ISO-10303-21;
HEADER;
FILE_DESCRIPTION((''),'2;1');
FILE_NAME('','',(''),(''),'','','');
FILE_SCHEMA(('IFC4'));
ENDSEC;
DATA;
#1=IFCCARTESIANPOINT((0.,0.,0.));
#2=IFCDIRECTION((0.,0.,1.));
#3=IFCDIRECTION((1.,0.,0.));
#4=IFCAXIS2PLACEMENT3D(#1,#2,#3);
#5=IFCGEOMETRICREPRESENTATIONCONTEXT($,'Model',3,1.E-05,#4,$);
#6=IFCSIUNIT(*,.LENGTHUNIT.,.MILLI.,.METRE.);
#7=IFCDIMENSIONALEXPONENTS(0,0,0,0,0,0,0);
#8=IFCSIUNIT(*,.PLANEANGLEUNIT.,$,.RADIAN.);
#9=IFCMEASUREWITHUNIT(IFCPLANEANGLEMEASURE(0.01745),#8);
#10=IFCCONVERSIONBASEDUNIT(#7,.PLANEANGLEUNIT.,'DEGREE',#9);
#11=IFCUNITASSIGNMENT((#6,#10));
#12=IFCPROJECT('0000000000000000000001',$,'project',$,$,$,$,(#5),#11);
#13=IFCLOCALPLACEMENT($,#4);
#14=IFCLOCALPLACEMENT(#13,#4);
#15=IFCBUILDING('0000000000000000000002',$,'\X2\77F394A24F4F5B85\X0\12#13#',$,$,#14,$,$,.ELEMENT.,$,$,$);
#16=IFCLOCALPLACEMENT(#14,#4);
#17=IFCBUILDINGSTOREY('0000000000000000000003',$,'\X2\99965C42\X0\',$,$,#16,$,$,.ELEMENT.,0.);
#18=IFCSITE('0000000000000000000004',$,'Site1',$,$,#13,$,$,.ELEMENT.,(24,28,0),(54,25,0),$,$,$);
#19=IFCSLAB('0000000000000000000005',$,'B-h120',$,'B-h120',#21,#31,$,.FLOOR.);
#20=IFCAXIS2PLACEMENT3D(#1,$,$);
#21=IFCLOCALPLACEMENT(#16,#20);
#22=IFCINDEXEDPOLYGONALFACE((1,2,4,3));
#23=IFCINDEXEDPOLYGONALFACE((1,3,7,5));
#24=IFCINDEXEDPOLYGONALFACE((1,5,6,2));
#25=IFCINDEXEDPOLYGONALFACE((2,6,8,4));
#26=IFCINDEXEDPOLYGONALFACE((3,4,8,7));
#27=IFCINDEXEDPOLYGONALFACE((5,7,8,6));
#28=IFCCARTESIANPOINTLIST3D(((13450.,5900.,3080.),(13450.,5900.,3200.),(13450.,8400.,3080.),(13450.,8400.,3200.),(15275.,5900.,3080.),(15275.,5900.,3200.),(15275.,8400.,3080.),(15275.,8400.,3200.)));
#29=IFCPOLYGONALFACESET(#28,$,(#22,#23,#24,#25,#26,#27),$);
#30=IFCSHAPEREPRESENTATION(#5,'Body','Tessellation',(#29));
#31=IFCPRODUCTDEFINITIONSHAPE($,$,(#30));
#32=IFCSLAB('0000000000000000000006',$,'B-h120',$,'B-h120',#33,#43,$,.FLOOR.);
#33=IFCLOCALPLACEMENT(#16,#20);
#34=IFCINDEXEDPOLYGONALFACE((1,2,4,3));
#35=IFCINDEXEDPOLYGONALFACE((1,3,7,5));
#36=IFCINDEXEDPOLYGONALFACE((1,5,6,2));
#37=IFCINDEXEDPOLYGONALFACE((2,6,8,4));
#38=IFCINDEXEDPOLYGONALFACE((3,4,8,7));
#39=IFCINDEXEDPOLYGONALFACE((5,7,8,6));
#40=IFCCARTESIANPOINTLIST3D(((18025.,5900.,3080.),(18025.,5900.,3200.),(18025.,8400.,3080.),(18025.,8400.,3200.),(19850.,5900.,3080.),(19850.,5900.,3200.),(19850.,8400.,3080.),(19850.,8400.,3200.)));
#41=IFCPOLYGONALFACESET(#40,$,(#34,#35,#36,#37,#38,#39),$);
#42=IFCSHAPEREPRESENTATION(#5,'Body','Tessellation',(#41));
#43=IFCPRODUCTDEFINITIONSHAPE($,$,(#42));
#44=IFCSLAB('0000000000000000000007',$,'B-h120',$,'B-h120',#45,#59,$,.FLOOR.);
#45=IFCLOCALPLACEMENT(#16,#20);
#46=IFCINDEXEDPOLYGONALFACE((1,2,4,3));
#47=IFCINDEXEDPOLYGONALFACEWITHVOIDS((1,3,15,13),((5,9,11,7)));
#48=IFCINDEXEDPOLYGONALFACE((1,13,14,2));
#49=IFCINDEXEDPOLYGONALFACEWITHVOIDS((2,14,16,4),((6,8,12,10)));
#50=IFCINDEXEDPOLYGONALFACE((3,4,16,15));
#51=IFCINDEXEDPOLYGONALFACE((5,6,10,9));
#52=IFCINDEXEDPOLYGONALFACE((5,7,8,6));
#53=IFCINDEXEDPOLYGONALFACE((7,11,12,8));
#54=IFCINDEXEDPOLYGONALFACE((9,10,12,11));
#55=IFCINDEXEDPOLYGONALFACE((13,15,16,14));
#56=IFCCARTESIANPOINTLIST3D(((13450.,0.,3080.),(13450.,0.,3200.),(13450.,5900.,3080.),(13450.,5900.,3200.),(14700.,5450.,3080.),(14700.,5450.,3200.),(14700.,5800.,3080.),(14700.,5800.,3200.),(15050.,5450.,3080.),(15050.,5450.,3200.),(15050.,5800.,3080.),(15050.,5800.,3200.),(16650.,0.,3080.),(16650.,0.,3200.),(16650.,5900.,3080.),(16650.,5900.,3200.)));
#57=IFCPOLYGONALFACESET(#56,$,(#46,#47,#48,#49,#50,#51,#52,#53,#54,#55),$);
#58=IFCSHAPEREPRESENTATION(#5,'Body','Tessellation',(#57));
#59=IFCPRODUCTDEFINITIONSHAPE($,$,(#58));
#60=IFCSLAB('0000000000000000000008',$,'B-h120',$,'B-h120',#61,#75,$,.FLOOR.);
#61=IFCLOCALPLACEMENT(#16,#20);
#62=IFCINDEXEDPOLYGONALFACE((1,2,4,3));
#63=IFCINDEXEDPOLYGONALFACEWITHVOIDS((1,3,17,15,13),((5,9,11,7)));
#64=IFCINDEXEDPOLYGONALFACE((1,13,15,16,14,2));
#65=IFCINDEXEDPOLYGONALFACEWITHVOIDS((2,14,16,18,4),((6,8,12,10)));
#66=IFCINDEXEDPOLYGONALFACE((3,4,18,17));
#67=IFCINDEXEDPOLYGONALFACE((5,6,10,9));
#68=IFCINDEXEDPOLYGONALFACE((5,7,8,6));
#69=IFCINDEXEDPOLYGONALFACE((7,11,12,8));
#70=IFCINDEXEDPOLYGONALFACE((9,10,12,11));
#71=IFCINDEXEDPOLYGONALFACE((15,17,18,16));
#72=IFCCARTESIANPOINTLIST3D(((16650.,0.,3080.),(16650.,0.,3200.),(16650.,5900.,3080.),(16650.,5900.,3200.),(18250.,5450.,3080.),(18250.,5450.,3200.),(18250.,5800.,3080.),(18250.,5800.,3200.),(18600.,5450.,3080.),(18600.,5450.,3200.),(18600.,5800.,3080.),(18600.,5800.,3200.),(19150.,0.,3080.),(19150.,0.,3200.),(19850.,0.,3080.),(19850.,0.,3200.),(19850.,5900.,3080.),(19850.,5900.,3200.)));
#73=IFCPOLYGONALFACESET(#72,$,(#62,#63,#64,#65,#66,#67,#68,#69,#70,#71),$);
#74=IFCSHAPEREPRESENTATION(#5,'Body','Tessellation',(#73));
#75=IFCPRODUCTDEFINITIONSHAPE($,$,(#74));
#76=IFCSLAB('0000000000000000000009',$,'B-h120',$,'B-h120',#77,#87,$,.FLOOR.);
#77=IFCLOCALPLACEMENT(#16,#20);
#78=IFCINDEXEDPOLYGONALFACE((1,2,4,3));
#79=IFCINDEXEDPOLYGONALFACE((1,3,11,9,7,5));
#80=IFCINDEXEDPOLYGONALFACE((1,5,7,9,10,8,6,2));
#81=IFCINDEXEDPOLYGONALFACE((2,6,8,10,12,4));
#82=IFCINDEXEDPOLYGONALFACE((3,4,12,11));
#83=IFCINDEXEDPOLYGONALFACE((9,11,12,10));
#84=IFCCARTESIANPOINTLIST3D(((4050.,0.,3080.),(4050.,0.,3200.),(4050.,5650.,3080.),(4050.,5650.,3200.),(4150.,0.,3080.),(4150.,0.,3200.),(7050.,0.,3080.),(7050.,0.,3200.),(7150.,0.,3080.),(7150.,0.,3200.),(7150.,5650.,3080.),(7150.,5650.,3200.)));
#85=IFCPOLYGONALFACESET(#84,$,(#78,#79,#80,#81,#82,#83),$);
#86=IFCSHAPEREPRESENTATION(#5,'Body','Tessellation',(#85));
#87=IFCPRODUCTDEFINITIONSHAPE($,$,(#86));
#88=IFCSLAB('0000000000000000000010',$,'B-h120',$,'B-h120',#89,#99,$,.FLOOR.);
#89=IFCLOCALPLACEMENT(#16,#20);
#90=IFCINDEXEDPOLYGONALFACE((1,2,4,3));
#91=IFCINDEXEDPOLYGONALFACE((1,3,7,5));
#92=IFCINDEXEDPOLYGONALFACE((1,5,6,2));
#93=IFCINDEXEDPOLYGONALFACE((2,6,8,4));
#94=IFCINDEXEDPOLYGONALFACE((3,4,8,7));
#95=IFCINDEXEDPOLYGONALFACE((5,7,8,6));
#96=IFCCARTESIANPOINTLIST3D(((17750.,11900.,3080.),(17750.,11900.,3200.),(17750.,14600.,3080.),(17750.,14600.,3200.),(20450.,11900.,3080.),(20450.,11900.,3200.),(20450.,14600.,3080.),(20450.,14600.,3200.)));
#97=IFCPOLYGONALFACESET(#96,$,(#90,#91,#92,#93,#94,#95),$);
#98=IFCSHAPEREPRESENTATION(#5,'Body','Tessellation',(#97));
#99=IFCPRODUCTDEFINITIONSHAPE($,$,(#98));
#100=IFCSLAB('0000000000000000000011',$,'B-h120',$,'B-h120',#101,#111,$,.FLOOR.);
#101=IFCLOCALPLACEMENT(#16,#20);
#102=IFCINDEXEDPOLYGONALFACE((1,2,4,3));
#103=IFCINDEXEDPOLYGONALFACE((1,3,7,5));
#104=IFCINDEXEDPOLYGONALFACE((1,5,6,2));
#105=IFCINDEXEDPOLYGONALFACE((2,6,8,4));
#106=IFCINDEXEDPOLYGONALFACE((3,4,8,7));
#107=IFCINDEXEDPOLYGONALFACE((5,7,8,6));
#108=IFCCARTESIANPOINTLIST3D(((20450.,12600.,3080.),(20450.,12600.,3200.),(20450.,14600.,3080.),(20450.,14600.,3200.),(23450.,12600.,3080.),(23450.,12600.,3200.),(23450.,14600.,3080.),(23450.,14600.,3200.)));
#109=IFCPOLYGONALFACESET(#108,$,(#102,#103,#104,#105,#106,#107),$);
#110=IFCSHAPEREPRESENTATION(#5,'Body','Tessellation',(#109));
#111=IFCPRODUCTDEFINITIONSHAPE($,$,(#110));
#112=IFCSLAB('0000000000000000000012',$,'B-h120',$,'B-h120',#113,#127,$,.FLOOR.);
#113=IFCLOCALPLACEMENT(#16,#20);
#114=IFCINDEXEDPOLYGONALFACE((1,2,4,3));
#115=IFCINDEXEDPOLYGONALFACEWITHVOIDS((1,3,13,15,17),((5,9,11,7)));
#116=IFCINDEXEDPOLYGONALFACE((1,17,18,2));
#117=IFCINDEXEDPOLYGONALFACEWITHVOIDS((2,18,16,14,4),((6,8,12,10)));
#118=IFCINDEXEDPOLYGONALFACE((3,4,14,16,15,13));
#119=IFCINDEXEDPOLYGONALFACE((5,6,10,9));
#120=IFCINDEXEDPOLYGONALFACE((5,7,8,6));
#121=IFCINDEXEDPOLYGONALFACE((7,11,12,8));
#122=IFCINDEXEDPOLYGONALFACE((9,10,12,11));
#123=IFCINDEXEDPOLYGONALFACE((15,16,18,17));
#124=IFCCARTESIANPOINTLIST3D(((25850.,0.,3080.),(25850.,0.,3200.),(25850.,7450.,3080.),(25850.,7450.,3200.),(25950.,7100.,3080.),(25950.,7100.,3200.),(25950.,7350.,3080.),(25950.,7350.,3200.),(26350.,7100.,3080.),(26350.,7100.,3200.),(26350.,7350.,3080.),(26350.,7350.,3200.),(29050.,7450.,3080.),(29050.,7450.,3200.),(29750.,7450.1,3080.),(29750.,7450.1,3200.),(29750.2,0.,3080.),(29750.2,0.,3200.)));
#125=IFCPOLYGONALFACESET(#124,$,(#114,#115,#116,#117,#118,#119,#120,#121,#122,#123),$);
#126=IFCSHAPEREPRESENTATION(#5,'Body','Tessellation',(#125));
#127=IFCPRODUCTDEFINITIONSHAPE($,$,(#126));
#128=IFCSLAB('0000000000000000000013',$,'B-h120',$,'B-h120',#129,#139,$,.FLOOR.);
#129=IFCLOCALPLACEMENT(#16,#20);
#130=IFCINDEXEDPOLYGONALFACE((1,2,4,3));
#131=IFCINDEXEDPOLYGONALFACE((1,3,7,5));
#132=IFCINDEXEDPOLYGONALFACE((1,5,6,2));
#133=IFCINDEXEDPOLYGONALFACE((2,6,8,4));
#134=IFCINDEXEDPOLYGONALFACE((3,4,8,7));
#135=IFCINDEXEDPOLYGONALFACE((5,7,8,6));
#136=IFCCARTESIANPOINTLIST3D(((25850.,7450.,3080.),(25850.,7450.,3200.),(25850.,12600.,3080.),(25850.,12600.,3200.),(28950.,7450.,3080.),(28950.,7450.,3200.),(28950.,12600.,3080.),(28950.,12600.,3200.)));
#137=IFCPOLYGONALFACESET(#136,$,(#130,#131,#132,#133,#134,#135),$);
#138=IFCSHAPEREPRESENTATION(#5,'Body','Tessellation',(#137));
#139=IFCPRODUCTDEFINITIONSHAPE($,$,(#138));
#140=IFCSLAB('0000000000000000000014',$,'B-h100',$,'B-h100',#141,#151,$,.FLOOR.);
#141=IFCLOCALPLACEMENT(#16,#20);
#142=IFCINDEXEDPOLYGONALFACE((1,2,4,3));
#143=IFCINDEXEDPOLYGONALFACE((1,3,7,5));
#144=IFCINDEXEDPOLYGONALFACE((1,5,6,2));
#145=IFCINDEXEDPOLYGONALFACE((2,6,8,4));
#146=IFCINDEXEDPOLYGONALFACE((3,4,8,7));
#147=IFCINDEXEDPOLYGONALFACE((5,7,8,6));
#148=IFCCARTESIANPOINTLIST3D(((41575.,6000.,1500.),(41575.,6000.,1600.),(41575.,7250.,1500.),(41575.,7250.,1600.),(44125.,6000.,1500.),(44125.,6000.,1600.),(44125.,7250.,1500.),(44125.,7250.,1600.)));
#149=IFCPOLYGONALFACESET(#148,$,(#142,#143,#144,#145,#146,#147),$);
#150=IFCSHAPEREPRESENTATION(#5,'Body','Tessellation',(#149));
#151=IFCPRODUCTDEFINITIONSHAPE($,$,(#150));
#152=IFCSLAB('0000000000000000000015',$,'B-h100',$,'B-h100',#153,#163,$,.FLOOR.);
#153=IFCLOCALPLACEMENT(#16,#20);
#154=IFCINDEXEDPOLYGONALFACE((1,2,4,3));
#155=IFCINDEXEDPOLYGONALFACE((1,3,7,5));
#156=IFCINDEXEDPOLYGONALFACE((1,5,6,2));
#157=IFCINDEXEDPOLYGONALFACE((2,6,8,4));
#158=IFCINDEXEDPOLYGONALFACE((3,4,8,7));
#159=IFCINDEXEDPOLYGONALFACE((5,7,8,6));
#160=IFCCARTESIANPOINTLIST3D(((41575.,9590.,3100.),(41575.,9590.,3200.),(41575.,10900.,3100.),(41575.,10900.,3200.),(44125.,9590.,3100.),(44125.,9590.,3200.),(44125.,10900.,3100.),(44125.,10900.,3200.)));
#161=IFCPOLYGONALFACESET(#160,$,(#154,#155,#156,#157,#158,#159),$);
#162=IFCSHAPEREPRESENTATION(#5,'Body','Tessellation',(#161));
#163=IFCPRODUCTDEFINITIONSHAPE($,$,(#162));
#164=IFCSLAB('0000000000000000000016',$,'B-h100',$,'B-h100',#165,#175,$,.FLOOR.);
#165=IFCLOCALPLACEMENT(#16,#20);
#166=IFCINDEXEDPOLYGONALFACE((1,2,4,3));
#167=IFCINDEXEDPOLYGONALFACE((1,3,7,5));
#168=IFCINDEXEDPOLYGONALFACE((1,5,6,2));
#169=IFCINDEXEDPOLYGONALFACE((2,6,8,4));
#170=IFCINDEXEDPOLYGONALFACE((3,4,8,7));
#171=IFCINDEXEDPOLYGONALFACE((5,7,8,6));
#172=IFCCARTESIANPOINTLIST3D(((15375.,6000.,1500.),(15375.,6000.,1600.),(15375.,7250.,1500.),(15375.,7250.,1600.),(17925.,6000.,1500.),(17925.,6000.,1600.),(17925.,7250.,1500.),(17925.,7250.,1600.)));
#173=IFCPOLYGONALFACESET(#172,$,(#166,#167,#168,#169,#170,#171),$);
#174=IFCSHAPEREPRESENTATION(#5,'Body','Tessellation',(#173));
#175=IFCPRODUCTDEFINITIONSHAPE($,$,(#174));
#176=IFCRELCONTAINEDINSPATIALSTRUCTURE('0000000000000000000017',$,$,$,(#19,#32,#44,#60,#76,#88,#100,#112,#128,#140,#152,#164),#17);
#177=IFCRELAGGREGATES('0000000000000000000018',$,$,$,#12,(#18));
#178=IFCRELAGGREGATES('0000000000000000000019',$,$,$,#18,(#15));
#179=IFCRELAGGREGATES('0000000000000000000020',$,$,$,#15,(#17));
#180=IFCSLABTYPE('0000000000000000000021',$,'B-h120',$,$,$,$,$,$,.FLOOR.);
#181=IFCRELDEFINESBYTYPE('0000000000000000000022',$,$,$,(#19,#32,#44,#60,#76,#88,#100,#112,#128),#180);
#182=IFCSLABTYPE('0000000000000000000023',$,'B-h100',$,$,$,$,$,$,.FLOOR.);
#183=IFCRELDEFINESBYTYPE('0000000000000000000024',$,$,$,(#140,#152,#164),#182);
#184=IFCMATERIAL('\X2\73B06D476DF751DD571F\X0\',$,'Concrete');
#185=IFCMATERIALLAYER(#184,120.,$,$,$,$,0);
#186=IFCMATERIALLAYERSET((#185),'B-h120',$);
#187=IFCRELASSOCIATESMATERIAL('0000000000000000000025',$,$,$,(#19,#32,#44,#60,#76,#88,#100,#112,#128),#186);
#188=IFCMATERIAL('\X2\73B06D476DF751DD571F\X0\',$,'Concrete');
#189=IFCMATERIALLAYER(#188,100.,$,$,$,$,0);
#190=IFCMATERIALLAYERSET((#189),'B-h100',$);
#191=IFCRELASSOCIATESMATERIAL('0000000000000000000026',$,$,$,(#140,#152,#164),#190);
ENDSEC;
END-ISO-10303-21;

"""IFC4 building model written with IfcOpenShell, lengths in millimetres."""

from ifc_helpers import new_model, entity, si_unit, converted_unit, frame, origin_with_axes, place, context, project, spatial, polyline, outline, extrude, material, layer, layer_set, type_object, element, save


model = new_model("IFC4")

# Units and contexts
model_context = context("Model", 3, precision=1e-05, world=origin_with_axes())
ifc_project = project(units=[si_unit("LENGTHUNIT", "METRE", prefix="MILLI"), converted_unit("PLANEANGLEUNIT", "DEGREE", entity("IfcPlaneAngleMeasure", 0.01745), si_unit("PLANEANGLEUNIT", "RADIAN"), dimensions=[0, 0, 0, 0, 0, 0, 0])], contexts=[model_context])

# Site, building, storey
site_placement = place(None, origin_with_axes())
site = spatial("IfcSite", under=ifc_project, at=site_placement, Name="Site1", CompositionType="ELEMENT", RefLatitude=(24, 28, 0), RefLongitude=(54, 25, 0))
building_placement = place(site_placement, origin_with_axes())
building = spatial("IfcBuilding", under=site, at=building_placement, Name="石钢住宅12#13#", CompositionType="ELEMENT")
storey_placement = place(building_placement, origin_with_axes())
storey = spatial("IfcBuildingStorey", under=building, at=storey_placement, Name="首层", CompositionType="ELEMENT", Elevation=0.0)

# Slabs
ifc_material_1 = material(Name="现浇混凝土", Category="Concrete")
ifc_layer_1 = layer(ifc_material_1, 120.0, Priority=0)
ifc_layer_set_1 = layer_set([ifc_layer_1], Name="B-h120")
slab_type_1 = type_object("IfcSlabType", Name="B-h120", PredefinedType="FLOOR")
slab_1_placement = place(storey_placement, origin_with_axes())
element("IfcSlab", 1, at=slab_1_placement, inside=storey, type_object=slab_type_1, material=ifc_layer_set_1, Name="B-h120", ObjectType="B-h120", PredefinedType="FLOOR", context=model_context, shape_type="SweptSolid", body=[
    extrude(outline(polyline([(0.0, 0.0), (2500.0, 0.0), (2500.0, 1825.0), (0.0, 1825.0), (0.0, 0.0)])), frame((13450.0, 5900.0, 3200.0), z_axis=(0.0, 0.0, -1.0), x_axis=(0.0, 1.0, 0.0)), (0.0, 0.0, 1.0), 120.0),
])
slab_2_placement = place(storey_placement, origin_with_axes())
element("IfcSlab", 2, at=slab_2_placement, inside=storey, type_object=slab_type_1, material=ifc_layer_set_1, Name="B-h120", ObjectType="B-h120", PredefinedType="FLOOR", context=model_context, shape_type="SweptSolid", body=[
    extrude(outline(polyline([(0.0, 0.0), (1825.0, 0.0), (1825.0, 2500.0), (0.0, 2500.0), (0.0, 0.0)])), frame((19850.0, 5900.0, 3200.0), z_axis=(0.0, 0.0, -1.0), x_axis=(-1.0, 0.0, 0.0)), (0.0, 0.0, 1.0), 120.0),
])

# Slabs, openings
slab_3_placement = place(storey_placement, origin_with_axes())
slab_3 = element("IfcSlab", 3, at=slab_3_placement, inside=storey, type_object=slab_type_1, material=ifc_layer_set_1, Name="B-h120", ObjectType="B-h120", PredefinedType="FLOOR", context=model_context, shape_type="SweptSolid", body=[
    extrude(outline(polyline([(0.0, 0.0), (3200.0, 0.0), (3200.0, 5900.0), (0.0, 5900.0), (0.0, 0.0)])), frame((16650.0, 0.0, 3200.0), z_axis=(0.0, 0.0, -1.0), x_axis=(-1.0, 0.0, 0.0)), (0.0, 0.0, 1.0), 120.0),
])
opening_1_placement = place(storey_placement, origin_with_axes())
element("IfcOpeningElement", 4, at=opening_1_placement, cuts=slab_3, PredefinedType="OPENING", context=model_context, shape_type="SweptSolid", body=[
    extrude(outline(polyline([(0.0, 0.0), (350.0, 0.0), (350.0, 350.0), (0.0, 350.0), (0.0, 0.0)])), frame((14700.0, 5450.0, -6400.0), z_axis=(0.0, 0.0, 1.0), x_axis=(1.0, 0.0, 0.0)), (0.0, 0.0, 1.0), 19200.0),
])
slab_4_placement = place(storey_placement, origin_with_axes())
slab_4 = element("IfcSlab", 5, at=slab_4_placement, inside=storey, type_object=slab_type_1, material=ifc_layer_set_1, Name="B-h120", ObjectType="B-h120", PredefinedType="FLOOR", context=model_context, shape_type="SweptSolid", body=[
    extrude(outline(polyline([(16650.0, 0.0), (16650.0, -5900.0), (19850.0, -5900.0), (19850.0, 0.0), (19150.0, 0.0), (19150.0, 0.0), (16650.0, 0.0)])), frame((0.0, 0.0, 3200.0), z_axis=(0.0, 0.0, -1.0), x_axis=(1.0, 0.0, 0.0)), (0.0, 0.0, 1.0), 120.0),
])
opening_2_placement = place(storey_placement, origin_with_axes())
element("IfcOpeningElement", 6, at=opening_2_placement, cuts=slab_4, PredefinedType="OPENING", context=model_context, shape_type="SweptSolid", body=[
    extrude(outline(polyline([(0.0, 0.0), (350.0, 0.0), (350.0, 350.0), (0.0, 350.0), (0.0, 0.0)])), frame((18250.0, 5450.0, -6400.0), z_axis=(0.0, 0.0, 1.0), x_axis=(1.0, 0.0, 0.0)), (0.0, 0.0, 1.0), 19200.0),
])

# Slabs
slab_5_placement = place(storey_placement, origin_with_axes())
element("IfcSlab", 7, at=slab_5_placement, inside=storey, type_object=slab_type_1, material=ifc_layer_set_1, Name="B-h120", ObjectType="B-h120", PredefinedType="FLOOR", context=model_context, shape_type="SweptSolid", body=[
    extrude(outline(polyline([(4050.0, -5650.0), (7150.0, -5650.0), (7150.0, 0.0), (7050.0, 0.0), (7050.0, 0.0), (4150.0, 0.0), (4150.0, 0.0), (4050.0, 0.0), (4050.0, -5650.0)])), frame((0.0, 0.0, 3200.0), z_axis=(0.0, 0.0, -1.0), x_axis=(1.0, 0.0, 0.0)), (0.0, 0.0, 1.0), 120.0),
])
slab_6_placement = place(storey_placement, origin_with_axes())
element("IfcSlab", 8, at=slab_6_placement, inside=storey, type_object=slab_type_1, material=ifc_layer_set_1, Name="B-h120", ObjectType="B-h120", PredefinedType="FLOOR", context=model_context, shape_type="SweptSolid", body=[
    extrude(outline(polyline([(0.0, 0.0), (2700.0, 0.0), (2700.0, 2700.0), (0.0, 2700.0), (0.0, 0.0)])), frame((20450.0, 14600.0, 3200.0), z_axis=(0.0, 0.0, -1.0), x_axis=(0.0, -1.0, 0.0)), (0.0, 0.0, 1.0), 120.0),
])
slab_7_placement = place(storey_placement, origin_with_axes())
element("IfcSlab", 9, at=slab_7_placement, inside=storey, type_object=slab_type_1, material=ifc_layer_set_1, Name="B-h120", ObjectType="B-h120", PredefinedType="FLOOR", context=model_context, shape_type="SweptSolid", body=[
    extrude(outline(polyline([(0.0, 0.0), (3000.0, 0.0), (3000.0, 2000.0), (0.0, 2000.0), (0.0, 0.0)])), frame((20450.0, 14600.0, 3200.0), z_axis=(0.0, 0.0, -1.0), x_axis=(1.0, 0.0, 0.0)), (0.0, 0.0, 1.0), 120.0),
])

# Slab, opening
slab_8_placement = place(storey_placement, origin_with_axes())
slab_8 = element("IfcSlab", 10, at=slab_8_placement, inside=storey, type_object=slab_type_1, material=ifc_layer_set_1, Name="B-h120", ObjectType="B-h120", PredefinedType="FLOOR", context=model_context, shape_type="SweptSolid", body=[
    extrude(outline(polyline([(29750.2, 0.0), (25850.0, 0.0), (25850.0, -7450.0), (29050.0, -7450.0), (29050.0, -7450.0), (29750.0, -7450.1), (29750.2, 0.0)])), frame((0.0, 0.0, 3200.0), z_axis=(0.0, 0.0, -1.0), x_axis=(1.0, 0.0, 0.0)), (0.0, 0.0, 1.0), 120.0),
])
opening_3_placement = place(storey_placement, origin_with_axes())
element("IfcOpeningElement", 11, at=opening_3_placement, cuts=slab_8, PredefinedType="OPENING", context=model_context, shape_type="SweptSolid", body=[
    extrude(outline(polyline([(0.0, 0.0), (400.0, 0.0), (400.0, 250.0), (0.0, 250.0), (0.0, 0.0)])), frame((25950.0, 7100.0, -6400.0), z_axis=(0.0, 0.0, 1.0), x_axis=(1.0, 0.0, 0.0)), (0.0, 0.0, 1.0), 19200.0),
])

# Slabs
slab_9_placement = place(storey_placement, origin_with_axes())
element("IfcSlab", 12, at=slab_9_placement, inside=storey, type_object=slab_type_1, material=ifc_layer_set_1, Name="B-h120", ObjectType="B-h120", PredefinedType="FLOOR", context=model_context, shape_type="SweptSolid", body=[
    extrude(outline(polyline([(0.0, 0.0), (5150.0, 0.0), (5150.0, 3100.0), (0.0, 3100.0), (0.0, 0.0)])), frame((25850.0, 7450.0, 3200.0), z_axis=(0.0, 0.0, -1.0), x_axis=(0.0, 1.0, 0.0)), (0.0, 0.0, 1.0), 120.0),
])
ifc_material_2 = material(Name="现浇混凝土", Category="Concrete")
ifc_layer_2 = layer(ifc_material_2, 100.0, Priority=0)
ifc_layer_set_2 = layer_set([ifc_layer_2], Name="B-h100")
slab_type_2 = type_object("IfcSlabType", Name="B-h100", PredefinedType="FLOOR")
slab_10_placement = place(storey_placement, origin_with_axes())
element("IfcSlab", 13, at=slab_10_placement, inside=storey, type_object=slab_type_2, material=ifc_layer_set_2, Name="B-h100", ObjectType="B-h100", PredefinedType="FLOOR", context=model_context, shape_type="SweptSolid", body=[
    extrude(outline(polyline([(0.0, 0.0), (2550.0, 0.0), (2550.0, 1250.0), (0.0, 1250.0), (0.0, 0.0)])), frame((41575.0, 7250.0, 1600.0), z_axis=(0.0, 0.0, -1.0), x_axis=(1.0, 0.0, 0.0)), (0.0, 0.0, 1.0), 100.0),
])
slab_11_placement = place(storey_placement, origin_with_axes())
element("IfcSlab", 14, at=slab_11_placement, inside=storey, type_object=slab_type_2, material=ifc_layer_set_2, Name="B-h100", ObjectType="B-h100", PredefinedType="FLOOR", context=model_context, shape_type="SweptSolid", body=[
    extrude(outline(polyline([(0.0, 0.0), (1310.0, 0.0), (1310.0, 2550.0), (0.0, 2550.0), (0.0, 0.0)])), frame((41575.0, 9590.0, 3200.0), z_axis=(0.0, 0.0, -1.0), x_axis=(0.0, 1.0, 0.0)), (0.0, 0.0, 1.0), 100.0),
])
slab_12_placement = place(storey_placement, origin_with_axes())
element("IfcSlab", 15, at=slab_12_placement, inside=storey, type_object=slab_type_2, material=ifc_layer_set_2, Name="B-h100", ObjectType="B-h100", PredefinedType="FLOOR", context=model_context, shape_type="SweptSolid", body=[
    extrude(outline(polyline([(0.0, 0.0), (1250.0, 0.0), (1250.0, 2550.0), (0.0, 2550.0), (0.0, 0.0)])), frame((17925.0, 7250.0, 1600.0), z_axis=(0.0, 0.0, -1.0), x_axis=(0.0, -1.0, 0.0)), (0.0, 0.0, 1.0), 100.0),
])

save(model, "model.ifc")
